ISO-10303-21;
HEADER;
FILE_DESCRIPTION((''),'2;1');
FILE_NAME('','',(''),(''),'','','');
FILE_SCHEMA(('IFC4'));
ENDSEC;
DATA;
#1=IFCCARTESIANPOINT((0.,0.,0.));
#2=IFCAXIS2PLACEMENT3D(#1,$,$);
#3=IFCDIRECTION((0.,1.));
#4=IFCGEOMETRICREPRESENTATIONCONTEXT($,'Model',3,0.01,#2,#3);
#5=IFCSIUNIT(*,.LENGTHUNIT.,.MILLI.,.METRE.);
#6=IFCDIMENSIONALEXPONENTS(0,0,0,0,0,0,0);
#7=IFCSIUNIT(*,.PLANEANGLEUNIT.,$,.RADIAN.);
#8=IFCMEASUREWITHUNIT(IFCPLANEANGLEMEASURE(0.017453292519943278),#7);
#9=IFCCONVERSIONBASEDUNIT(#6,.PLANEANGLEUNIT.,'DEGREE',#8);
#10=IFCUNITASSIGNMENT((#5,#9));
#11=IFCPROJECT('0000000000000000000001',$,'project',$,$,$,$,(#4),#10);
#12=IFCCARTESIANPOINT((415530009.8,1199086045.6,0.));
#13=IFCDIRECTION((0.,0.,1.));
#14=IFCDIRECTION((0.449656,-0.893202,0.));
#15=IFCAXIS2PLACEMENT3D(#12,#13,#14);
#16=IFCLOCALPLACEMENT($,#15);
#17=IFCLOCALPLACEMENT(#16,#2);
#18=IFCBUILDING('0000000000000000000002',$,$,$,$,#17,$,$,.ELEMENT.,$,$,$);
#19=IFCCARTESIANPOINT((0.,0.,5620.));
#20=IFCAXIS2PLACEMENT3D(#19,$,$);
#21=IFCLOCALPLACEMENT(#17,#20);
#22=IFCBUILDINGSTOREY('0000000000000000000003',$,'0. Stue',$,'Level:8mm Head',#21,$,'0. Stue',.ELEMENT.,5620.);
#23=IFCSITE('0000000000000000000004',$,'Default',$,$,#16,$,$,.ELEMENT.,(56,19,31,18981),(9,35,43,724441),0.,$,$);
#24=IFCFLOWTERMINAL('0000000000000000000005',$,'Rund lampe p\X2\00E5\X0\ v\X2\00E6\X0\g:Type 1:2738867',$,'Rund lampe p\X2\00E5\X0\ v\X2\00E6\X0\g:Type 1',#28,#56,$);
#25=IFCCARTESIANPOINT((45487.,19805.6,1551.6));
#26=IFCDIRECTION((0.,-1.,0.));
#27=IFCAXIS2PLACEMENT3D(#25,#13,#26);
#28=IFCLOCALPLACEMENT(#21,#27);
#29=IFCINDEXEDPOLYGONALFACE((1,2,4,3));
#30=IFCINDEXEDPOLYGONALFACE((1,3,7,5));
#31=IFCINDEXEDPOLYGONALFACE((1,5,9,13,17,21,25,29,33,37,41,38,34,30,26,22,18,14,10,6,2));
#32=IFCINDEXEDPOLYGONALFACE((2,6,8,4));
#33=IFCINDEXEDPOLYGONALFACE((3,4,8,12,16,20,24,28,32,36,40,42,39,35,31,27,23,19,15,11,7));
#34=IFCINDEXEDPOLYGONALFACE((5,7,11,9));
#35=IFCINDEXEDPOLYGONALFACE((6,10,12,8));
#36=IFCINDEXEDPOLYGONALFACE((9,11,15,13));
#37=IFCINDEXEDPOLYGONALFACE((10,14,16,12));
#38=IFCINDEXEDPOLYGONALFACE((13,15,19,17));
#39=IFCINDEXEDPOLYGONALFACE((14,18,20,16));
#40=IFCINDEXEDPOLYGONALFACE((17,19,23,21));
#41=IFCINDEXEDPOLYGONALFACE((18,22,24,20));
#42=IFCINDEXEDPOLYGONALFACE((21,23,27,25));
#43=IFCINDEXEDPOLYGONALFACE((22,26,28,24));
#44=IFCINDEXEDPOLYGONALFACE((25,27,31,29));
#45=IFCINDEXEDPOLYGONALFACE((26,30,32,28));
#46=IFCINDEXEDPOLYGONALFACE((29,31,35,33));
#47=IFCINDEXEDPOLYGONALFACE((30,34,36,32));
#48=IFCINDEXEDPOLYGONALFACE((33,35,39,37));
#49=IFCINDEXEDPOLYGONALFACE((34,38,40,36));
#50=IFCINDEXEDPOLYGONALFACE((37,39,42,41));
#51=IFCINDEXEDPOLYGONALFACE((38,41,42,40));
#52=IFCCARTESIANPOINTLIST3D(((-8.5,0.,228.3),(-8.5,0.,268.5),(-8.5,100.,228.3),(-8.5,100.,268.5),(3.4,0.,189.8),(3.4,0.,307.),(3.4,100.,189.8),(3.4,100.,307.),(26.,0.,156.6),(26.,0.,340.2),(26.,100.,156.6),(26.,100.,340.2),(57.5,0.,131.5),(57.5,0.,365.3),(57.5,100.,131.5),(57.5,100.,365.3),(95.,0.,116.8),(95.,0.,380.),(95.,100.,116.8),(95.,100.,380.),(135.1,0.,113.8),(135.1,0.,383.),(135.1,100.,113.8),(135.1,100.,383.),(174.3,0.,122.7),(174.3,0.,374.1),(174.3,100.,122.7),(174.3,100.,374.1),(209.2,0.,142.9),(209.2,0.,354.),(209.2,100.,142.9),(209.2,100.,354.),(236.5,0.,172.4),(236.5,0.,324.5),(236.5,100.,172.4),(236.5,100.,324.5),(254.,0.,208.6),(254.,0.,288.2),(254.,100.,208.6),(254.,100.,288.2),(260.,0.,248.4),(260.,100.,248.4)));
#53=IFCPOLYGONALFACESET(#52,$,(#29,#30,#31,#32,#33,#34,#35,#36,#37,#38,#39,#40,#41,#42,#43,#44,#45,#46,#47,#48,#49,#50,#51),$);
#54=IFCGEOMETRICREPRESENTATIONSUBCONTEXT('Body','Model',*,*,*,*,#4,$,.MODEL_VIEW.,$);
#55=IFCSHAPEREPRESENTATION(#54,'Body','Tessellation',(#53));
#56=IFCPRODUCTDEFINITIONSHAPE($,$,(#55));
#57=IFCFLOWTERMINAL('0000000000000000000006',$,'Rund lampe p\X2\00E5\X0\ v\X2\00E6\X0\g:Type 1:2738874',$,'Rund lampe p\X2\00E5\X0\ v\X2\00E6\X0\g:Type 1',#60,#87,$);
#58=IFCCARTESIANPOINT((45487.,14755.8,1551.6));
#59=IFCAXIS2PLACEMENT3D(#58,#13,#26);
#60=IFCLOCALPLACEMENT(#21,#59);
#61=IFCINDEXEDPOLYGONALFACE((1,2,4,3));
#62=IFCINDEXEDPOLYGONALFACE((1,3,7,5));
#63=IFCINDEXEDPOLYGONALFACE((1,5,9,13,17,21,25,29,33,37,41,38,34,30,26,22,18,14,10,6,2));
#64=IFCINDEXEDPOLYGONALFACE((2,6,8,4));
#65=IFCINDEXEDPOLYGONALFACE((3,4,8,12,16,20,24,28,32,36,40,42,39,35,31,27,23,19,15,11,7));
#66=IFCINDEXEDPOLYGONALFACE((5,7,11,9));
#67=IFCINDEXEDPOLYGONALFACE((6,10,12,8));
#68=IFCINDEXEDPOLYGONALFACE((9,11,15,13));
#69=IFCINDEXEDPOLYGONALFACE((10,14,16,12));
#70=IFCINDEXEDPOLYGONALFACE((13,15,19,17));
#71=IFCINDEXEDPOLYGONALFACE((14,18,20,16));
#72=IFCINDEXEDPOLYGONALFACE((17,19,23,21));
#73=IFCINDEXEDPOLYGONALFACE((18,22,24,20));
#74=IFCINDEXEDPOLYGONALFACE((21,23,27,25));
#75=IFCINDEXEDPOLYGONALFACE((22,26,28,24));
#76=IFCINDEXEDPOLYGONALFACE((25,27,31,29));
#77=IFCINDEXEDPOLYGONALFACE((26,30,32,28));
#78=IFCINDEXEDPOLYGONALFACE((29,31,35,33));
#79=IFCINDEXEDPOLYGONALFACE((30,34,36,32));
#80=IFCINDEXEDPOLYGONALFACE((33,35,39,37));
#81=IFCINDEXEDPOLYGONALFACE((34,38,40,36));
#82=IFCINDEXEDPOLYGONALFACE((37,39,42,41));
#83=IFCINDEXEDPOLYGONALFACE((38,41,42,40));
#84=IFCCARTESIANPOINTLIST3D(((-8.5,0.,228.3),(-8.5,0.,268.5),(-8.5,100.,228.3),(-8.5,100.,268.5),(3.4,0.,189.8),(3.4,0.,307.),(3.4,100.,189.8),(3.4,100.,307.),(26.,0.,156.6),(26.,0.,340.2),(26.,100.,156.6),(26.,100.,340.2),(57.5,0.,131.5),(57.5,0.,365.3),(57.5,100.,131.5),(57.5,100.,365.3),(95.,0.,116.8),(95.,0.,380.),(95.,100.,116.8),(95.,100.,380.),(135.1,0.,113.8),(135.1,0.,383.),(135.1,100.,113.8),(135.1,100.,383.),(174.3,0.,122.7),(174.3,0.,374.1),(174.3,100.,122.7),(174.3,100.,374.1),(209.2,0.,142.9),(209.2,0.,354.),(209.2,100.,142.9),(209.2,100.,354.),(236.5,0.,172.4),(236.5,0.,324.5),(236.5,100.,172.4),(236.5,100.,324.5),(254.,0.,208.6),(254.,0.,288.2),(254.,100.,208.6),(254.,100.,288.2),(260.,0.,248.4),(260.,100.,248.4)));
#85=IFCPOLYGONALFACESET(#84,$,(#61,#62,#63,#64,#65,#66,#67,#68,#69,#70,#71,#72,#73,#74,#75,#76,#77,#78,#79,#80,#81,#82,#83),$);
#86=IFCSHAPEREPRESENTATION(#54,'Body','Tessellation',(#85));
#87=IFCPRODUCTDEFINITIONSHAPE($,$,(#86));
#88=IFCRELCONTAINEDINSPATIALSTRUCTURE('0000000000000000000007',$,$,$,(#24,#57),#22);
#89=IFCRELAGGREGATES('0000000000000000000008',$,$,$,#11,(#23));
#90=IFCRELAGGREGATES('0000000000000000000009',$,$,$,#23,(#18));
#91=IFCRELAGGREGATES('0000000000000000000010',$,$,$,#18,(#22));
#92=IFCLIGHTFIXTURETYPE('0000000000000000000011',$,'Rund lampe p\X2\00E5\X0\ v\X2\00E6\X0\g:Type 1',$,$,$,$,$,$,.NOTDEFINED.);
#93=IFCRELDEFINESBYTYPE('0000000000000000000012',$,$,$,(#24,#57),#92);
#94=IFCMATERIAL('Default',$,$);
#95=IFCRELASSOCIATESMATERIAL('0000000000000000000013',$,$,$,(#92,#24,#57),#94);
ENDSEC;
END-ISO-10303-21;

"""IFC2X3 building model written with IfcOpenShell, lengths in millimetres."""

from ifc_helpers import new_model, entity, si_unit, converted_unit, direction, frame, frame_2d, origin, place, context, subcontext, project, spatial, circle, extrude, source, transform, mapped, material, type_object, type_shapes, element, save


model = new_model("IFC2X3")

# Units and contexts
model_context = context("Model", 3, precision=0.01, world=origin(), true_north=direction((0.0, 1.0)))
body_context = subcontext(model_context, "Body", "Model", "MODEL_VIEW")
ifc_project = project(units=[si_unit("LENGTHUNIT", "METRE", prefix="MILLI"), converted_unit("PLANEANGLEUNIT", "DEGREE", entity("IfcPlaneAngleMeasure", 0.017453292519943278), si_unit("PLANEANGLEUNIT", "RADIAN"), dimensions=[0, 0, 0, 0, 0, 0, 0])], contexts=[model_context])

# Site, building, storey
site_placement = place(None, frame((415530009.8, 1199086045.6, 0.0), z_axis=(0.0, 0.0, 1.0), x_axis=(0.449656, -0.893202, 0.0)))
site = spatial("IfcSite", under=ifc_project, at=site_placement, Name="Default", CompositionType="ELEMENT", RefLatitude=(56, 19, 31, 18981), RefLongitude=(9, 35, 43, 724441), RefElevation=0.0)
building_placement = place(site_placement, origin())
building = spatial("IfcBuilding", under=site, at=building_placement, CompositionType="ELEMENT")
storey_placement = place(building_placement, frame((0.0, 0.0, 5620.0)))
storey = spatial("IfcBuildingStorey", under=building, at=storey_placement, Name="0. Stue", ObjectType="Level:8mm Head", LongName="0. Stue", CompositionType="ELEMENT", Elevation=5620.0)

# Flow terminals
ifc_material_1 = material(Name="Default")
light_fixture_type_1 = type_object("IfcLightFixtureType", Name="Rund lampe på væg:Type 1", PredefinedType="NOTDEFINED", material=ifc_material_1)
shared_shape_1 = source(origin(), body_context, "Body", "SweptSolid", [
    extrude(circle(Radius=135.0, at=frame_2d((0.0, 0.0), x_axis=(1.0, 0.0))), frame((125.0, 0.0, 248.4), z_axis=(0.0, 1.0, 0.0), x_axis=(1.0, 0.0, 0.0)), (0.0, 0.0, 1.0), 100.0),
])
type_shapes(light_fixture_type_1, [shared_shape_1])
for number, where, z_axis, x_axis, name in (
    (1, (45487.0, 19805.6, 1551.6), (0.0, 0.0, 1.0), (0.0, -1.0, 0.0), "Rund lampe på væg:Type 1:2738867"),
    (2, (45487.0, 14755.8, 1551.6), (0.0, 0.0, 1.0), (0.0, -1.0, 0.0), "Rund lampe på væg:Type 1:2738874"),
):
    element("IfcFlowTerminal", number, at=place(storey_placement, frame(where, z_axis=z_axis, x_axis=x_axis)), inside=storey, type_object=light_fixture_type_1, material=ifc_material_1, Name=name, ObjectType="Rund lampe på væg:Type 1", context=body_context, shape_type="MappedRepresentation", body=[
        mapped(shared_shape_1, transform((0.0, 0.0, 0.0), scale=1.0)),
    ])

save(model, "model.ifc")
